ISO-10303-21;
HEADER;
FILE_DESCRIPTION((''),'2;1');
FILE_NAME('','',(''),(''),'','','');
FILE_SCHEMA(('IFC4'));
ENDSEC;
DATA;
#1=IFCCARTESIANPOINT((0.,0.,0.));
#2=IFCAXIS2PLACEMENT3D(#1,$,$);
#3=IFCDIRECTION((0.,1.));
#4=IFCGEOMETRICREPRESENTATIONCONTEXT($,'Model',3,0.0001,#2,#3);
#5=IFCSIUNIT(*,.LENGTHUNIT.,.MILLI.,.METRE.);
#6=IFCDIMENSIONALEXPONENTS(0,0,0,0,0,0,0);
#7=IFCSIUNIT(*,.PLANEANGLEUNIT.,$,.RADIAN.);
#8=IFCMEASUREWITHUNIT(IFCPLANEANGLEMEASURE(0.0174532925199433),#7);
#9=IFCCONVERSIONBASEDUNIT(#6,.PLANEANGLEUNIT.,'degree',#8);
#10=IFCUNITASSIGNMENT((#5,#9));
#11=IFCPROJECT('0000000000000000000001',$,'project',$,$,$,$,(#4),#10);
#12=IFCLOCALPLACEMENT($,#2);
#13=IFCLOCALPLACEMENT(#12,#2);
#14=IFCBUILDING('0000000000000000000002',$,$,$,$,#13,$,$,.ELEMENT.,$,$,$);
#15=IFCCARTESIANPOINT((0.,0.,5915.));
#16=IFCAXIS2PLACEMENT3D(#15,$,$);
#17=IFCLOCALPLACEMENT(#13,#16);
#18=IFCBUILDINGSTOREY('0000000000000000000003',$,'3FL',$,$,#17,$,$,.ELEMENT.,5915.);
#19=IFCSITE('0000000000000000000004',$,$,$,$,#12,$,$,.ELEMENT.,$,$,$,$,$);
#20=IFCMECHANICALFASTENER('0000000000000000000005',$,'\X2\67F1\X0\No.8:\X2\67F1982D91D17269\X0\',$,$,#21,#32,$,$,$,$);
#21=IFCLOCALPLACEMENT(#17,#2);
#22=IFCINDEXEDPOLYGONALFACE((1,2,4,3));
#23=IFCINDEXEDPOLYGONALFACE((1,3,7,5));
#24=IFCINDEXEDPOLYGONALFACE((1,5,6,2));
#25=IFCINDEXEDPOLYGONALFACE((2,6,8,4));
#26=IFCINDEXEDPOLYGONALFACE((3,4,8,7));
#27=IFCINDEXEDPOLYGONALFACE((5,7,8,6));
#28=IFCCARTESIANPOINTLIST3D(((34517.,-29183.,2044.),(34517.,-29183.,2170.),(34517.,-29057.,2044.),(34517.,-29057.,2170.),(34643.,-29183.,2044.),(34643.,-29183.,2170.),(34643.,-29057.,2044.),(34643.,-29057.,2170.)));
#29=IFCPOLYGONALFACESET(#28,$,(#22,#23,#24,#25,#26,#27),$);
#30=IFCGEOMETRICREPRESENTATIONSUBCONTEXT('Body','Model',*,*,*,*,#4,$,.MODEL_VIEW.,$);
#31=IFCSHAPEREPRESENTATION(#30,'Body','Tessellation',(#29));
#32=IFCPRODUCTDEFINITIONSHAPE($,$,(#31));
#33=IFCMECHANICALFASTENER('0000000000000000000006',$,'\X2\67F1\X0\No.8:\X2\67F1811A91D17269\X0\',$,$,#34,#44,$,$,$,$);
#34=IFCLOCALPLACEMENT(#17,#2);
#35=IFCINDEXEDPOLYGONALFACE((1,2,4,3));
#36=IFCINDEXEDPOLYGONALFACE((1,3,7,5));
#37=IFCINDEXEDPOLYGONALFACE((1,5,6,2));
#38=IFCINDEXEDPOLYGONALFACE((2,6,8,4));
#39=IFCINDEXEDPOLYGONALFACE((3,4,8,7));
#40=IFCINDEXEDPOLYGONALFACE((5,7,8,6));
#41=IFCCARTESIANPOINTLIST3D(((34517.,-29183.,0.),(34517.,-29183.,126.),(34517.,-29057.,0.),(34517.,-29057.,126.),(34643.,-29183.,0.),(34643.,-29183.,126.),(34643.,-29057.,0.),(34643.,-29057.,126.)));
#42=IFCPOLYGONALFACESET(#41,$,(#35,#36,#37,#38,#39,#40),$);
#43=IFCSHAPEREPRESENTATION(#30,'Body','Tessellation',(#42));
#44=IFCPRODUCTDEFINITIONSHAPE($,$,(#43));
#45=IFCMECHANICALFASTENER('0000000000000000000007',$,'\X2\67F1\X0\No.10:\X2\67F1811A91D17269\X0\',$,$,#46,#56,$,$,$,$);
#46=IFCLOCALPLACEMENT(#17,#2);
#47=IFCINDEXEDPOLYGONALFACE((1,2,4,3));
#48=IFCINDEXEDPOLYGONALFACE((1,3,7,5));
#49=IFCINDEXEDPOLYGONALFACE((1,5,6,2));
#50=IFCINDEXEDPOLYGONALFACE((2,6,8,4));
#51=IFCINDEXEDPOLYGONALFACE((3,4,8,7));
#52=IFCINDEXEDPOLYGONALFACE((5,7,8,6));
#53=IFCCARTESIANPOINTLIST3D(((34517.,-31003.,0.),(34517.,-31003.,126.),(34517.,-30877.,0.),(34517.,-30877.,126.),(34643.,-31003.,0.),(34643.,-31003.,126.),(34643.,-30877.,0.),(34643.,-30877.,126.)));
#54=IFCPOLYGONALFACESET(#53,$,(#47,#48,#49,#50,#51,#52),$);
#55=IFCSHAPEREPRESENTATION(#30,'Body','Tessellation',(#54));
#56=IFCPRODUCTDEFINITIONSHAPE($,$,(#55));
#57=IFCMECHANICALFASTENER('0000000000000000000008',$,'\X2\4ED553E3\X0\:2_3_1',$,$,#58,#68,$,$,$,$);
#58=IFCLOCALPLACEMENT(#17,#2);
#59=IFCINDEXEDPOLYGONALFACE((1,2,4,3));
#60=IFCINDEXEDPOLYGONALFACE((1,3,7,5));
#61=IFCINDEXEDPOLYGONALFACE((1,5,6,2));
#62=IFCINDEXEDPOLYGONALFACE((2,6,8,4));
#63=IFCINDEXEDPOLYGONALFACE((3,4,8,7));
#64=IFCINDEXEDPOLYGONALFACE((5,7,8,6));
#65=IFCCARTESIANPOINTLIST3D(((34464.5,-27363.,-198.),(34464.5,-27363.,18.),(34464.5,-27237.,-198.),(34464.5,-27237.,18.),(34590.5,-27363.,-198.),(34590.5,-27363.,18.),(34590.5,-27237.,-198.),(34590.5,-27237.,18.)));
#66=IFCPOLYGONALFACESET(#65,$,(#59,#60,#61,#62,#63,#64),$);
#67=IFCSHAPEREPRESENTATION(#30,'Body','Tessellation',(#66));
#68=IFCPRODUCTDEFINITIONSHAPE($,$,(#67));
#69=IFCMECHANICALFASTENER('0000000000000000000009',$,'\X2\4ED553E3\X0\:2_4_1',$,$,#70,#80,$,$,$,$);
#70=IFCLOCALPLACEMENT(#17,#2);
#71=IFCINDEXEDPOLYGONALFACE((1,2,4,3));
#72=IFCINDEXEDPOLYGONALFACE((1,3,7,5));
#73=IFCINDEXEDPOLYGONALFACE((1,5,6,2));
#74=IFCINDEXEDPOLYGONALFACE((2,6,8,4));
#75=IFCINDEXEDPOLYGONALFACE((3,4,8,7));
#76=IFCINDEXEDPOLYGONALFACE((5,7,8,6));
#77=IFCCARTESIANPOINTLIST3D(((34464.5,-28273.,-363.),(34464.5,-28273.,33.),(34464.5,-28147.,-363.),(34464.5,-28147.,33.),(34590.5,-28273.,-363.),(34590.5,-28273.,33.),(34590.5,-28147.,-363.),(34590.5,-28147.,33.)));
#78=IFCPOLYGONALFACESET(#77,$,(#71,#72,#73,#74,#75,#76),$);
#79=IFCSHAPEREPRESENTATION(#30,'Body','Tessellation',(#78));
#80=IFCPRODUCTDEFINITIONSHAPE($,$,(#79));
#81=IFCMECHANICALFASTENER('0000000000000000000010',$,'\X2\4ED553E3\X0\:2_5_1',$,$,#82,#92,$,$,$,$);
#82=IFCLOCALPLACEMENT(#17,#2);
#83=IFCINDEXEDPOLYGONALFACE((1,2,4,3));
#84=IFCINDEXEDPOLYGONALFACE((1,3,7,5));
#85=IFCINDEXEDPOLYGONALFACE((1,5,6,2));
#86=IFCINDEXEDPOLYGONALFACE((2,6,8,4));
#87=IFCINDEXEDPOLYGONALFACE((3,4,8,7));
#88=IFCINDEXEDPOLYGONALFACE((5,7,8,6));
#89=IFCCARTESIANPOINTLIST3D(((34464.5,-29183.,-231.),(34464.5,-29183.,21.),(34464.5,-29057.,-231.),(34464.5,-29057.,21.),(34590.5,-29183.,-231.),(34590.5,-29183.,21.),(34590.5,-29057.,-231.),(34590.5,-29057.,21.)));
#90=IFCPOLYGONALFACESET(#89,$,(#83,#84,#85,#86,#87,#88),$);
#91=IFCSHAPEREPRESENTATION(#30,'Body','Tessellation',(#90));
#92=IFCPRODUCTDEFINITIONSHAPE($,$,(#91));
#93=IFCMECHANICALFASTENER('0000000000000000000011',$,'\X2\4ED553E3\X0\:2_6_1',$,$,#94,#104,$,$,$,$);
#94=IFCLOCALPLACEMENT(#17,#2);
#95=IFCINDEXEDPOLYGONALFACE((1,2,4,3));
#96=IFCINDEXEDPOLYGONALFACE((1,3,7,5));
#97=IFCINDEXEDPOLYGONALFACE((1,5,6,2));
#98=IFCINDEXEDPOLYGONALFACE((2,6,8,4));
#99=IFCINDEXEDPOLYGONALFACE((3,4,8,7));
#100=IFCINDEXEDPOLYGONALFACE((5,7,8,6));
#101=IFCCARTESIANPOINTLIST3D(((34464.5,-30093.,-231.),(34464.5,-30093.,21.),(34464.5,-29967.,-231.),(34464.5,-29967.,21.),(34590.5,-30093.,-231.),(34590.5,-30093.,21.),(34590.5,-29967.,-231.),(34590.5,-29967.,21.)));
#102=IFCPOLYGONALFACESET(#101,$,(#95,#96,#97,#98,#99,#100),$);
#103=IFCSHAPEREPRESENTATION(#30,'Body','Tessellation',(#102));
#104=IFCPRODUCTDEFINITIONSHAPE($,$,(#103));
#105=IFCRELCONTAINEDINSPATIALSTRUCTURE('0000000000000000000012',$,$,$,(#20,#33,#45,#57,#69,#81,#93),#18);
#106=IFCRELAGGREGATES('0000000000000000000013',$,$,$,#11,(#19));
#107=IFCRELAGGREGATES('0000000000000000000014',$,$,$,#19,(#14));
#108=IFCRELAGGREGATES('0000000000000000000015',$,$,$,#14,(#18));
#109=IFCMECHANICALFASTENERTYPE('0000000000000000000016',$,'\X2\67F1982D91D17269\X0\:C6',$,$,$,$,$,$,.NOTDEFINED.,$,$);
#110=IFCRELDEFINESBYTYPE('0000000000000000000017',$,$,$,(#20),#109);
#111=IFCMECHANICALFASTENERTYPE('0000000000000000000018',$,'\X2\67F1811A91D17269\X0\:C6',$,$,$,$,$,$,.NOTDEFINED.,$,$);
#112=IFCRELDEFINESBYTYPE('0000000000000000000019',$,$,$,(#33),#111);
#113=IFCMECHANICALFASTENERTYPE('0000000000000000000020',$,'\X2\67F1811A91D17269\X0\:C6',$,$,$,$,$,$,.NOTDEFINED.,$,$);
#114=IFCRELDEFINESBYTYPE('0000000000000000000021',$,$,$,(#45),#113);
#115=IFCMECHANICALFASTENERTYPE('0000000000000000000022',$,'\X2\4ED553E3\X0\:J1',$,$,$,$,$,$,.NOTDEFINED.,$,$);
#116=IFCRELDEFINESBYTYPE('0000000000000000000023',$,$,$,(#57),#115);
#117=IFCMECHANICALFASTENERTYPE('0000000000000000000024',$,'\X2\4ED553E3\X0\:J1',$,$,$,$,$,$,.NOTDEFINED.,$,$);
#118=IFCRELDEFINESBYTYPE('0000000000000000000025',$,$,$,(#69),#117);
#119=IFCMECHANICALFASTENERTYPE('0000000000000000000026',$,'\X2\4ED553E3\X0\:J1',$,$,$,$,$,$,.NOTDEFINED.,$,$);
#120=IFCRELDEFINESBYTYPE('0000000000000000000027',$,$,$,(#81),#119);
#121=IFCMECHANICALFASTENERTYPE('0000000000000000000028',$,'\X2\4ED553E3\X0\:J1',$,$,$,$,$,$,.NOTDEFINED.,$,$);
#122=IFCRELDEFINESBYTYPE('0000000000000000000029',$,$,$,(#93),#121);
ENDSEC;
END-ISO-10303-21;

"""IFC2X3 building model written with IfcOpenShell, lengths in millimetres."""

from ifc_helpers import new_model, entity, si_unit, converted_unit, direction, frame, origin, origin_with_axes, origin_2d, place, context, subcontext, project, spatial, rectangle, extrude, type_object, element, save


model = new_model("IFC2X3")

# Units and contexts
model_context = context("Model", 3, precision=0.0001, world=origin(), true_north=direction((0.0, 1.0)))
body_context = subcontext(model_context, "Body", "Model", "MODEL_VIEW")
ifc_project = project(units=[si_unit("LENGTHUNIT", "METRE", prefix="MILLI"), converted_unit("PLANEANGLEUNIT", "degree", entity("IfcPlaneAngleMeasure", 0.0174532925199433), si_unit("PLANEANGLEUNIT", "RADIAN"), dimensions=[0, 0, 0, 0, 0, 0, 0])], contexts=[model_context])

# Site, building, storey
site_placement = place(None, origin())
site = spatial("IfcSite", under=ifc_project, at=site_placement, CompositionType="ELEMENT")
building_placement = place(site_placement, origin())
building = spatial("IfcBuilding", under=site, at=building_placement, CompositionType="ELEMENT")
storey_placement = place(building_placement, frame((0.0, 0.0, 5915.0)))
storey = spatial("IfcBuildingStorey", under=building, at=storey_placement, Name="3FL", CompositionType="ELEMENT", Elevation=5915.0)

# Mechanical fasteners
mechanical_fastener_type_1 = type_object("IfcMechanicalFastenerType", Name="柱頭金物:C6")
mechanical_fastener_1_placement = place(storey_placement, frame((34580.0, -29120.0, 2044.0)))
element("IfcMechanicalFastener", 1, at=mechanical_fastener_1_placement, inside=storey, type_object=mechanical_fastener_type_1, Name="柱No.8:柱頭金物", context=body_context, shape_type="SweptSolid", body=[
    extrude(rectangle(XDim=126.0, YDim=126.0, at=origin_2d()), origin_with_axes(), (0.0, 0.0, 1.0), 126.0),
])
mechanical_fastener_type_2 = type_object("IfcMechanicalFastenerType", Name="柱脚金物:C6")
mechanical_fastener_2_placement = place(storey_placement, frame((34580.0, -29120.0, 0.0)))
element("IfcMechanicalFastener", 2, at=mechanical_fastener_2_placement, inside=storey, type_object=mechanical_fastener_type_2, Name="柱No.8:柱脚金物", context=body_context, shape_type="SweptSolid", body=[
    extrude(rectangle(XDim=126.0, YDim=126.0, at=origin_2d()), origin_with_axes(), (0.0, 0.0, 1.0), 126.0),
])
mechanical_fastener_type_3 = type_object("IfcMechanicalFastenerType", Name="柱脚金物:C6")
mechanical_fastener_3_placement = place(storey_placement, frame((34580.0, -30940.0, 0.0)))
element("IfcMechanicalFastener", 3, at=mechanical_fastener_3_placement, inside=storey, type_object=mechanical_fastener_type_3, Name="柱No.10:柱脚金物", context=body_context, shape_type="SweptSolid", body=[
    extrude(rectangle(XDim=126.0, YDim=126.0, at=origin_2d()), origin_with_axes(), (0.0, 0.0, 1.0), 126.0),
])
mechanical_fastener_type_4 = type_object("IfcMechanicalFastenerType", Name="仕口:J1")
mechanical_fastener_4_placement = place(storey_placement, frame((34527.5, -27300.0, -198.0)))
element("IfcMechanicalFastener", 4, at=mechanical_fastener_4_placement, inside=storey, type_object=mechanical_fastener_type_4, Name="仕口:2_3_1", context=body_context, shape_type="SweptSolid", body=[
    extrude(rectangle(XDim=126.0, YDim=126.0, at=origin_2d()), origin_with_axes(), (0.0, 0.0, 1.0), 216.0),
])
mechanical_fastener_type_5 = type_object("IfcMechanicalFastenerType", Name="仕口:J1")
mechanical_fastener_5_placement = place(storey_placement, frame((34527.5, -28210.0, -363.0)))
element("IfcMechanicalFastener", 5, at=mechanical_fastener_5_placement, inside=storey, type_object=mechanical_fastener_type_5, Name="仕口:2_4_1", context=body_context, shape_type="SweptSolid", body=[
    extrude(rectangle(XDim=126.0, YDim=126.0, at=origin_2d()), origin_with_axes(), (0.0, 0.0, 1.0), 396.0),
])
mechanical_fastener_type_6 = type_object("IfcMechanicalFastenerType", Name="仕口:J1")
mechanical_fastener_6_placement = place(storey_placement, frame((34527.5, -29120.0, -231.0)))
element("IfcMechanicalFastener", 6, at=mechanical_fastener_6_placement, inside=storey, type_object=mechanical_fastener_type_6, Name="仕口:2_5_1", context=body_context, shape_type="SweptSolid", body=[
    extrude(rectangle(XDim=126.0, YDim=126.0, at=origin_2d()), origin_with_axes(), (0.0, 0.0, 1.0), 252.0),
])
mechanical_fastener_type_7 = type_object("IfcMechanicalFastenerType", Name="仕口:J1")
mechanical_fastener_7_placement = place(storey_placement, frame((34527.5, -30030.0, -231.0)))
element("IfcMechanicalFastener", 7, at=mechanical_fastener_7_placement, inside=storey, type_object=mechanical_fastener_type_7, Name="仕口:2_6_1", context=body_context, shape_type="SweptSolid", body=[
    extrude(rectangle(XDim=126.0, YDim=126.0, at=origin_2d()), origin_with_axes(), (0.0, 0.0, 1.0), 252.0),
])

save(model, "model.ifc")
